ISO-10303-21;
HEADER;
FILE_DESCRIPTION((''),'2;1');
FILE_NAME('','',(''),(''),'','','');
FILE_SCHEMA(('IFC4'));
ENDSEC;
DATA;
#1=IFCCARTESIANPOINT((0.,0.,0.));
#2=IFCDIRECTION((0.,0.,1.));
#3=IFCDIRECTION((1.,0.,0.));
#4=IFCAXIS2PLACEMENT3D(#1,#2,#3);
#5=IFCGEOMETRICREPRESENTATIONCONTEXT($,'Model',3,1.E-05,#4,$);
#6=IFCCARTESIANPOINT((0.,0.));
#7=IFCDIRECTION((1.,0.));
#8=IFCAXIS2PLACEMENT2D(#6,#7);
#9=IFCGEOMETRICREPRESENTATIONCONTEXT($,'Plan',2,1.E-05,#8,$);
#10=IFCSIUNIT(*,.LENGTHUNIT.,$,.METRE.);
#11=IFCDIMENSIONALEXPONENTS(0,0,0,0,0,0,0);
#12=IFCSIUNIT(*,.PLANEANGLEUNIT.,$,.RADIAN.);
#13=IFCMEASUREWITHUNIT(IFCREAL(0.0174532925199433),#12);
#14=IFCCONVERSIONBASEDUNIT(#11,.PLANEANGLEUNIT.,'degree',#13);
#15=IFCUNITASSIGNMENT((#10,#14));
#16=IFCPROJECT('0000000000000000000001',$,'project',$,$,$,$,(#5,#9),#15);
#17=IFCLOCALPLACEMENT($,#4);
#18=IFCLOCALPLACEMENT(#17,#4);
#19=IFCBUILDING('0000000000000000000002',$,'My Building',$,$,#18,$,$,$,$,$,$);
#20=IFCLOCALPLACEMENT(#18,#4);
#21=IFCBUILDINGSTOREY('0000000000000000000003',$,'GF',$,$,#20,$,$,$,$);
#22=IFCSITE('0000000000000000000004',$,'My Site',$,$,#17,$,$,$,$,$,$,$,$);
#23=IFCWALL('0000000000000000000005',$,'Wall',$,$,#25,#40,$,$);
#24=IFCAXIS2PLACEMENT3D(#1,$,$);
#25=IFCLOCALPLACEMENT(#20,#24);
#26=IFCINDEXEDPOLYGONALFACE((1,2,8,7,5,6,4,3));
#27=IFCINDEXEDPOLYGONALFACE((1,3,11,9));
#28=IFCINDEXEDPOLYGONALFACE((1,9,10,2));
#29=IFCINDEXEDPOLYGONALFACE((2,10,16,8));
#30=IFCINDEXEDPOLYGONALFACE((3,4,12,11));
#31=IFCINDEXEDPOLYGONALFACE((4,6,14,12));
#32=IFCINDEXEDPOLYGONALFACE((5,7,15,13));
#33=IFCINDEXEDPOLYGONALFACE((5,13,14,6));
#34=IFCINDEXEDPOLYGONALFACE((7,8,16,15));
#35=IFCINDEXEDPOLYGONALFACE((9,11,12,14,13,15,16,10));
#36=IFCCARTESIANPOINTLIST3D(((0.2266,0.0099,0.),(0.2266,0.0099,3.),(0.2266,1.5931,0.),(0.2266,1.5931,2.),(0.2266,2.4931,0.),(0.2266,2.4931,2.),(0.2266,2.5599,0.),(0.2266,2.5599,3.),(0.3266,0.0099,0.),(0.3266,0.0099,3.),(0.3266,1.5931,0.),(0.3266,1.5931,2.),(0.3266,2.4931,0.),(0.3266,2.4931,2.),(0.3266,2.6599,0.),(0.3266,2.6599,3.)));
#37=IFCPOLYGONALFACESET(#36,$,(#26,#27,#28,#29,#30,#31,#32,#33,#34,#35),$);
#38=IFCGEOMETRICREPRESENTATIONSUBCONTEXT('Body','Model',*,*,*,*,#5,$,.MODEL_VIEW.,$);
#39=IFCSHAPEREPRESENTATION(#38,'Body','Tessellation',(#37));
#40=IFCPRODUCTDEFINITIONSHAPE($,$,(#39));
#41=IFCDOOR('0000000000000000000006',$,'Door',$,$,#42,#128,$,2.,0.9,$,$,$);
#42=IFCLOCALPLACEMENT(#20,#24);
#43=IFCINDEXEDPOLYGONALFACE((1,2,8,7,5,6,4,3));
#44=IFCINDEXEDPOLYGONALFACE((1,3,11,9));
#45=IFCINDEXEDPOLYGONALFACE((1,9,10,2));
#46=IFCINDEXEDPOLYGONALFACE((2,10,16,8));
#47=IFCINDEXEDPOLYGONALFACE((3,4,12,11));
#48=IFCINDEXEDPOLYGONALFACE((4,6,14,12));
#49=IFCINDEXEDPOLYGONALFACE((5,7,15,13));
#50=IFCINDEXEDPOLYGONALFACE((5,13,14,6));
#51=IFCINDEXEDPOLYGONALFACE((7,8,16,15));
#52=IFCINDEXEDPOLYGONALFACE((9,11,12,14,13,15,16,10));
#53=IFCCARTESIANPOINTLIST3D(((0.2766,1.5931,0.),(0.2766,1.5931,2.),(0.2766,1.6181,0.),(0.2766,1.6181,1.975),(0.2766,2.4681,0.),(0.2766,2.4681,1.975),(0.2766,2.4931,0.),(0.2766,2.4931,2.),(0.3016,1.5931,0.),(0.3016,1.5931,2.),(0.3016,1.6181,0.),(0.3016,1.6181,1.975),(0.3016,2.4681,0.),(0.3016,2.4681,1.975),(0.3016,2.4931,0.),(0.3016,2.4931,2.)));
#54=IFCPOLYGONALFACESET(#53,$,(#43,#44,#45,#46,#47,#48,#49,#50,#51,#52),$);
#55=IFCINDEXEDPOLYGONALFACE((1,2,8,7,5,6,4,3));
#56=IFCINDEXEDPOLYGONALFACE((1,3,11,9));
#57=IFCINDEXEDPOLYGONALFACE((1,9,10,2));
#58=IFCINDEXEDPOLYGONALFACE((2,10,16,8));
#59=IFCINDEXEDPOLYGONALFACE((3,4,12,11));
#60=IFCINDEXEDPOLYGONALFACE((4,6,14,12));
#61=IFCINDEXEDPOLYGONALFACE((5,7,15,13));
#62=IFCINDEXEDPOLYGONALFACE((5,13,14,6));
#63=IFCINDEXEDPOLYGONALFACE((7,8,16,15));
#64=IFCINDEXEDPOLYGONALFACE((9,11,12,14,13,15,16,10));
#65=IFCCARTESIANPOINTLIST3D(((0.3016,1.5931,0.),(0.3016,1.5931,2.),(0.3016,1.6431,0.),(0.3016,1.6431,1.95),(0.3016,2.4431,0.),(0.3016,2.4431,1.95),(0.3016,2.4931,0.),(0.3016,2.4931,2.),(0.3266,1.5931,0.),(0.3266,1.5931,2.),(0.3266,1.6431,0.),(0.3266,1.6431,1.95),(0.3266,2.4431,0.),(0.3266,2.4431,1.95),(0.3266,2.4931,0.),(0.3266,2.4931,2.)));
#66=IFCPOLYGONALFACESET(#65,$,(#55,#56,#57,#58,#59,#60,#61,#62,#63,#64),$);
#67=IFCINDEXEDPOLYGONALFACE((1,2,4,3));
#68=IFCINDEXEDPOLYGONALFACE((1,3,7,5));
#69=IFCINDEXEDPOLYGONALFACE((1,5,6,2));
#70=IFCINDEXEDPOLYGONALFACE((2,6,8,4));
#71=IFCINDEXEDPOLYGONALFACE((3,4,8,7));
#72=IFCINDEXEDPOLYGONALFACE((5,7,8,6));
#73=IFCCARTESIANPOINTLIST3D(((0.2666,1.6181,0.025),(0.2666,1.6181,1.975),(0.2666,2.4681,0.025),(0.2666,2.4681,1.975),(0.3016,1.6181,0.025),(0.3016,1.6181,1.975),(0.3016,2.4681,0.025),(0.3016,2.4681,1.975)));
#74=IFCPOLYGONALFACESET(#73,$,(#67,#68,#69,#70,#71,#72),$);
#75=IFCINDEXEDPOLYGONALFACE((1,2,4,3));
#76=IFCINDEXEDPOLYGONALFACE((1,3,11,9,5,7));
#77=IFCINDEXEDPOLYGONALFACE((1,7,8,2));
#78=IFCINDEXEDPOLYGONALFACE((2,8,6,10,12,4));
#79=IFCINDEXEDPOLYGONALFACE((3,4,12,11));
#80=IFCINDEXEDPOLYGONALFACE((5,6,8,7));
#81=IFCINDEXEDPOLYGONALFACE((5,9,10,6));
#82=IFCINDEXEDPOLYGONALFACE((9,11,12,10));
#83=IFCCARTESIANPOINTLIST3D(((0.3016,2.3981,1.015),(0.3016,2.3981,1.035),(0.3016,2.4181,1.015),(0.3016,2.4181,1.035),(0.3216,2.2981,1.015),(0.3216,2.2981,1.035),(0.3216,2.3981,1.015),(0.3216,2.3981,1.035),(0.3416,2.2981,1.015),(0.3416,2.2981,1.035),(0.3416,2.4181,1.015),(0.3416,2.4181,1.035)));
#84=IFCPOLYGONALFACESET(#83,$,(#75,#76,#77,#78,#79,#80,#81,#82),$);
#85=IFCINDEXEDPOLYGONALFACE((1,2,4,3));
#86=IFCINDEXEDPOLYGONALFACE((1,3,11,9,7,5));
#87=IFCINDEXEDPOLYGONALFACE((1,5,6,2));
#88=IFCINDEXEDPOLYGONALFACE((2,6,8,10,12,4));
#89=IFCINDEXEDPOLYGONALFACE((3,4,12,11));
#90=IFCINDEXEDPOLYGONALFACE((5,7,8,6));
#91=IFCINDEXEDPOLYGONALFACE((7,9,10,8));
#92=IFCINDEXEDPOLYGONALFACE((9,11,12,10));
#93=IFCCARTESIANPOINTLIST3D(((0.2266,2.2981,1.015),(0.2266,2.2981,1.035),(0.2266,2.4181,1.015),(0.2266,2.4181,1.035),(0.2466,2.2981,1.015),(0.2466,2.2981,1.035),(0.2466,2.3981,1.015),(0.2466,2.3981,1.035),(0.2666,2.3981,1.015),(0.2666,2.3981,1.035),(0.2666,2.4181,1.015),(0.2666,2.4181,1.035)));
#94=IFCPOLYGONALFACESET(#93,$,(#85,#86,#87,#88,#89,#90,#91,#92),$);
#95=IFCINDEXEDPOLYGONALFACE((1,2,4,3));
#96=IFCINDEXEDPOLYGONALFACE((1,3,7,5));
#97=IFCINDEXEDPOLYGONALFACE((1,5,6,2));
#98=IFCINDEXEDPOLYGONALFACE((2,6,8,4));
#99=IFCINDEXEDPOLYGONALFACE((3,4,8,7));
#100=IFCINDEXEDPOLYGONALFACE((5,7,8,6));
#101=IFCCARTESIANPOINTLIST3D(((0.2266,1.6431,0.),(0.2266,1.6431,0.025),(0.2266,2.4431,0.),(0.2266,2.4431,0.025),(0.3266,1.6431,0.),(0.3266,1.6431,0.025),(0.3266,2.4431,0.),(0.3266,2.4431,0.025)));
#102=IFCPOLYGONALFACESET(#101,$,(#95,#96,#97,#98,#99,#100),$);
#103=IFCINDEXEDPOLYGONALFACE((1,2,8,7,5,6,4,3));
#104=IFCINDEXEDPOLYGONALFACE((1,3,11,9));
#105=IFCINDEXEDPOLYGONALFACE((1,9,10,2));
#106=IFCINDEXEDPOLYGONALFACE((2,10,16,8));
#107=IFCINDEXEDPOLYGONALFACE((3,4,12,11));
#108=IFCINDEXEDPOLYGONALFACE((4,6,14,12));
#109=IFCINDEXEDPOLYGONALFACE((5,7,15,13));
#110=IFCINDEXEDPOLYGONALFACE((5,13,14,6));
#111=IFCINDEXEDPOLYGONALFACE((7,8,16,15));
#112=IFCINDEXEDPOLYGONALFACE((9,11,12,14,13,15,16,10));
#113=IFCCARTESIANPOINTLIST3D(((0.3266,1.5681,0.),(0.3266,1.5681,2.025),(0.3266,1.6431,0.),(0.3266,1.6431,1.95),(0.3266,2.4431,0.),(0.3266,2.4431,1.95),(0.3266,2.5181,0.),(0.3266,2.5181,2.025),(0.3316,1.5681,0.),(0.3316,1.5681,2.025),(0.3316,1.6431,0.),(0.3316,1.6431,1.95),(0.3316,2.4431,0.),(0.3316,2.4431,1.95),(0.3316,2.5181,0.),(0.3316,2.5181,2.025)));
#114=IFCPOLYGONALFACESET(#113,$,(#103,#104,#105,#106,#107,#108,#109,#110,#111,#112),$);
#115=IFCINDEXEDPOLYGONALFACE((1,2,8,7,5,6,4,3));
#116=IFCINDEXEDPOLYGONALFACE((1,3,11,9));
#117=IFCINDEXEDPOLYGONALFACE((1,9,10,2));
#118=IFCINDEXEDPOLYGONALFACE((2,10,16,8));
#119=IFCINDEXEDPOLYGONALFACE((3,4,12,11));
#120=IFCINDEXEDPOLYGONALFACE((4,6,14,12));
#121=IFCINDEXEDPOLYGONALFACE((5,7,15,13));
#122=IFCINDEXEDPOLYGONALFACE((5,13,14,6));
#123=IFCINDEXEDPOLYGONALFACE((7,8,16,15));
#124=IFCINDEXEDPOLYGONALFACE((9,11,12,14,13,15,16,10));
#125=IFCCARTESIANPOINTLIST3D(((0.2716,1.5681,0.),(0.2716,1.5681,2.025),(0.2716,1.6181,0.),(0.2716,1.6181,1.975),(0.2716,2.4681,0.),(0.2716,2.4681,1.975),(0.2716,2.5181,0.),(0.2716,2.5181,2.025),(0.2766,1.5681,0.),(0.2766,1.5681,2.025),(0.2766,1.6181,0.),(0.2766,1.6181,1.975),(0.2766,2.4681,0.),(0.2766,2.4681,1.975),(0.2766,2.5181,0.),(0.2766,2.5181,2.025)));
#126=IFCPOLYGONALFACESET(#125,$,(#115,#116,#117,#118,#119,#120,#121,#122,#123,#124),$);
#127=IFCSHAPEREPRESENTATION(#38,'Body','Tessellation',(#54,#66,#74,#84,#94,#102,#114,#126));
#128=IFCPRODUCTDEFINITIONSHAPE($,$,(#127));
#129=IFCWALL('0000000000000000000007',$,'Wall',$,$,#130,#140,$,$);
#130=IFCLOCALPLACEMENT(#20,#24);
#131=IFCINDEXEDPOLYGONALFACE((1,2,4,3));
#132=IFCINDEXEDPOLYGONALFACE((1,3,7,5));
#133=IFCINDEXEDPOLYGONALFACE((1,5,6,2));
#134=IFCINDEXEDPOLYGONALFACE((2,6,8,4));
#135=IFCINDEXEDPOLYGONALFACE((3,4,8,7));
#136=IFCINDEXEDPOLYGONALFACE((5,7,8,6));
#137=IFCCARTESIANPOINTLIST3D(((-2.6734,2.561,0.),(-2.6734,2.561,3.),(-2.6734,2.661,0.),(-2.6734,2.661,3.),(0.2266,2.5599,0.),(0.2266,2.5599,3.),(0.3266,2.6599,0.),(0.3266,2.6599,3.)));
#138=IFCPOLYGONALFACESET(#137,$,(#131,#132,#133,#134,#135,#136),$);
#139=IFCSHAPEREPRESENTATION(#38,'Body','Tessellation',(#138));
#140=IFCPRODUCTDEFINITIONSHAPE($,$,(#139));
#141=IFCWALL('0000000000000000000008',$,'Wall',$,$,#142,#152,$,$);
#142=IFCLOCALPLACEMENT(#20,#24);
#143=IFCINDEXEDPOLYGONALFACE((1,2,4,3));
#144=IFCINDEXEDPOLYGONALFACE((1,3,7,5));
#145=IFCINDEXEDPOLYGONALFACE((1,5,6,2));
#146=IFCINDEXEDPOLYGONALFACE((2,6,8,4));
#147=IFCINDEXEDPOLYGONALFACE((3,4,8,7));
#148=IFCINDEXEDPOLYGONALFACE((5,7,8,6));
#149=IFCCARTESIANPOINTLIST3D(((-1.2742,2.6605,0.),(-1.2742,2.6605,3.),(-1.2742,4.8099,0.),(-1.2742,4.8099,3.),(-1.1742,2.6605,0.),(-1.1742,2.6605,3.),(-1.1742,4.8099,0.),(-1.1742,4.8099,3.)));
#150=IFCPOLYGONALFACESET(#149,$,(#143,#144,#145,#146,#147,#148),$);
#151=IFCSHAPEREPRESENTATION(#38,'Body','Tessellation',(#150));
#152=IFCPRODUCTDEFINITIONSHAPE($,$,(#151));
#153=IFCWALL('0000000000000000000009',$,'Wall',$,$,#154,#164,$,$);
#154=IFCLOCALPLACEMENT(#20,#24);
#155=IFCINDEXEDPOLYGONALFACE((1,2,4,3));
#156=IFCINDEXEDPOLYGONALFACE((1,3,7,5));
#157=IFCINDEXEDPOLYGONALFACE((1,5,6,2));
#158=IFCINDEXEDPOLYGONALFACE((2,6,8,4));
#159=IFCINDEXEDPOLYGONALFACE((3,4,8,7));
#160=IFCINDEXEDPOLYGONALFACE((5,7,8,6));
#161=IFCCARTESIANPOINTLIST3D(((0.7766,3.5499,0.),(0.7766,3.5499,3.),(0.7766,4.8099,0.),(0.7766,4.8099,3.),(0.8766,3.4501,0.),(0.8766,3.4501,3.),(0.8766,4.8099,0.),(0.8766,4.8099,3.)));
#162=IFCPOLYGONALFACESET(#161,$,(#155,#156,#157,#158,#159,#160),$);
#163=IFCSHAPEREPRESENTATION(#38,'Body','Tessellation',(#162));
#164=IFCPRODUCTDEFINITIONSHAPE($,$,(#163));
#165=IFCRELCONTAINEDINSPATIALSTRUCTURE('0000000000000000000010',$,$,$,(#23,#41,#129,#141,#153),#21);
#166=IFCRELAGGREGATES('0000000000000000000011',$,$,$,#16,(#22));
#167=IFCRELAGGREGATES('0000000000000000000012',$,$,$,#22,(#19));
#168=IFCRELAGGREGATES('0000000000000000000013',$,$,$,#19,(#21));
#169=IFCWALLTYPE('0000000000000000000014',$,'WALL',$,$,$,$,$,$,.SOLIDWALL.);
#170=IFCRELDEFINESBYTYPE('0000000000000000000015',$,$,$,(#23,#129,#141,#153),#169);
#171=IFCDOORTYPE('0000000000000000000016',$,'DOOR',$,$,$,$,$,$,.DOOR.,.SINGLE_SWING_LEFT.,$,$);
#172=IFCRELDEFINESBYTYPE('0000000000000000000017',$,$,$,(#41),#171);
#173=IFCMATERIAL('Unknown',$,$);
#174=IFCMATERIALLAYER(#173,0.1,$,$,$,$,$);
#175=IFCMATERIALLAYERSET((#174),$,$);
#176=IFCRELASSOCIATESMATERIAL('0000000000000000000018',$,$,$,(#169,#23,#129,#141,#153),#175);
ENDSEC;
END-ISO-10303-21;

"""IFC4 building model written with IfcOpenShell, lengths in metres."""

from ifc_helpers import new_model, entity, si_unit, converted_unit, frame, origin_with_axes, origin_2d_with_axis, place, context, subcontext, project, spatial, line, indexed_curve, outline, extrude, shape, source, transform, mapped, material, layer, layer_set, layer_usage, type_object, type_shapes, element, fill, save


model = new_model("IFC4")

# Units and contexts
model_context = context("Model", 3, precision=1e-05, world=origin_with_axes())
plan_context = context("Plan", 2, precision=1e-05, world=origin_2d_with_axis())
body_context_1 = subcontext(model_context, "Body", "Model", "MODEL_VIEW")
body_context_2 = subcontext(plan_context, "Body", "Plan", "PLAN_VIEW")
ifc_project = project(units=[si_unit("LENGTHUNIT", "METRE"), converted_unit("PLANEANGLEUNIT", "degree", entity("IfcReal", 0.0174532925199433), si_unit("PLANEANGLEUNIT", "RADIAN"), dimensions=[0, 0, 0, 0, 0, 0, 0])], contexts=[model_context, plan_context])

# Site, building, storey
site_placement = place(None, origin_with_axes())
site = spatial("IfcSite", under=ifc_project, at=site_placement, Name="My Site")
building_placement = place(site_placement, origin_with_axes())
building = spatial("IfcBuilding", under=site, at=building_placement, Name="My Building")
storey_placement = place(building_placement, origin_with_axes())
storey = spatial("IfcBuildingStorey", under=building, at=storey_placement, Name="GF")

# Shared definitions
ifc_material_1 = material(Name="Unknown")

# Shared definitions
ifc_layer_1 = layer(ifc_material_1, 0.1)
ifc_layer_set_1 = layer_set([ifc_layer_1])
wall_type = type_object("IfcWallType", Name="WALL", PredefinedType="SOLIDWALL", material=ifc_layer_set_1)
shared_shape_1 = source(origin_with_axes(), body_context_1, "Body", "SweptSolid", [
    extrude(outline(indexed_curve([(0.0, 0.0), (0.9, 0.0), (0.9, 2.0), (0.0, 2.0)], segments=[line(1, 2, 3, 4, 1)])), frame((0.0, -0.6, 0.0), z_axis=(0.0, -1.0, 0.0), x_axis=(1.0, 0.0, 0.0)), (0.0, 0.0, -1.0), 1.2),
])
door_type = type_object("IfcDoorType", Name="DOOR", OperationType="SINGLE_SWING_LEFT", PredefinedType="DOOR")
shared_shape_2 = source(origin_with_axes(), body_context_1, "Body", "SweptSolid", [
    extrude(outline(indexed_curve([(0.0, 0.0), (0.0, 2.0), (0.9, 2.0), (0.9, 0.0), (0.875, 0.0), (0.875, 1.975), (0.025, 1.975), (0.025, 0.0)], segments=[line(1, 2, 3, 4, 5, 6, 7, 8, 1)])), frame((0.0, 0.025, 0.0), z_axis=(0.0, -1.0, 0.0), x_axis=(1.0, 0.0, 0.0)), (0.0, 0.0, -1.0), 0.025),
    extrude(outline(indexed_curve([(0.0, 0.0), (0.0, 2.0), (0.9, 2.0), (0.9, 0.0), (0.85, 0.0), (0.85, 1.95), (0.05, 1.95), (0.05, 0.0)], segments=[line(1, 2, 3, 4, 5, 6, 7, 8, 1)])), frame((0.0, 0.0, 0.0), z_axis=(0.0, -1.0, 0.0), x_axis=(1.0, 0.0, 0.0)), (0.0, 0.0, -1.0), 0.025),
    extrude(outline(indexed_curve([(0.0, 0.0), (0.85, 0.0), (0.85, 0.035), (0.0, 0.035)], segments=[line(1, 2, 3, 4, 1)])), frame((0.025, 0.025, 0.025), z_axis=(0.0, 0.0, 1.0), x_axis=(1.0, 0.0, 0.0)), (0.0, 0.0, 1.0), 1.95),
    extrude(outline(indexed_curve([(0.0, 0.0), (0.0, -0.04), (-0.12, -0.04), (-0.12, -0.02), (-0.02, -0.02), (-0.02, 0.0)], segments=[line(1, 2, 3, 4, 5, 6, 1)])), frame((0.825, 0.025, 1.015), z_axis=(0.0, 0.0, 1.0), x_axis=(1.0, 0.0, 0.0)), (0.0, 0.0, 1.0), 0.02),
    extrude(outline(indexed_curve([(0.0, 0.0), (0.0, 0.04), (-0.12, 0.04), (-0.12, 0.02), (-0.02, 0.02), (-0.02, 0.0)], segments=[line(1, 2, 3, 4, 5, 6, 1)])), frame((0.825, 0.06, 1.015), z_axis=(0.0, 0.0, 1.0), x_axis=(1.0, 0.0, 0.0)), (0.0, 0.0, 1.0), 0.02),
    extrude(outline(indexed_curve([(0.0, 0.0), (0.8, 0.0), (0.8, 0.1), (0.0, 0.1)], segments=[line(1, 2, 3, 4, 1)])), frame((0.05, 0.0, 0.0), z_axis=(0.0, 0.0, 1.0), x_axis=(1.0, 0.0, 0.0)), (0.0, 0.0, 1.0), 0.025),
    extrude(outline(indexed_curve([(0.0, 0.0), (0.0, 2.025), (0.95, 2.025), (0.95, 0.0), (0.875, 0.0), (0.875, 1.95), (0.075, 1.95), (0.075, 0.0)], segments=[line(1, 2, 3, 4, 5, 6, 7, 8, 1)])), frame((-0.025, -0.005, 0.0), z_axis=(0.0, -1.0, 0.0), x_axis=(1.0, 0.0, 0.0)), (0.0, 0.0, -1.0), 0.005),
    extrude(outline(indexed_curve([(0.0, 0.0), (0.0, 2.025), (0.95, 2.025), (0.95, 0.0), (0.9, 0.0), (0.9, 1.975), (0.05, 1.975), (0.05, 0.0)], segments=[line(1, 2, 3, 4, 5, 6, 7, 8, 1)])), frame((-0.025, 0.05, 0.0), z_axis=(0.0, -1.0, 0.0), x_axis=(1.0, 0.0, 0.0)), (0.0, 0.0, -1.0), 0.005),
])
shared_shape_3 = source(origin_with_axes(), body_context_2, "Body", "Curve2D", [
    entity("IfcIndexedPolyCurve", entity("IfcCartesianPointList2D", [[0.0, 0.0], [0.0, 0.05], [0.025, 0.05], [0.025, 0.025], [0.05, 0.025], [0.05, 0.0]]), [entity("IfcLineIndex", [1, 2, 3, 4, 5, 6, 1])]),
    entity("IfcIndexedPolyCurve", entity("IfcCartesianPointList2D", [[0.9, 0.0], [0.9, 0.05], [0.875, 0.05], [0.875, 0.025], [0.85, 0.025], [0.85, 0.0]]), [entity("IfcLineIndex", [1, 2, 3, 4, 5, 6, 1])]),
    entity("IfcTrimmedCurve", entity("IfcEllipse", entity("IfcAxis2Placement2D", entity("IfcCartesianPoint", [0.06, 0.05]), entity("IfcDirection", [1.0, 0.0])), 0.815, 0.85), [entity("IfcCartesianPoint", [0.875, 0.05])], [entity("IfcCartesianPoint", [0.06, 0.9])], True, "CARTESIAN"),
    entity("IfcIndexedPolyCurve", entity("IfcCartesianPointList2D", [[0.025, 0.05], [0.06, 0.05], [0.06, 0.9], [0.025, 0.9]]), [entity("IfcLineIndex", [1, 2, 3, 4, 1])]),
])
type_shapes(door_type, [shared_shape_2, shared_shape_3])

# Wall, opening, door
ifc_layer_usage_1 = layer_usage(ifc_layer_set_1, "AXIS2", "POSITIVE", 0.0)
wall_1_placement = place(storey_placement, frame((0.3266, 0.0099, 0.0), z_axis=(0.0, 0.0, 1.0), x_axis=(0.0, 1.0, 0.0)))
wall_1 = element("IfcWall", 1, at=wall_1_placement, inside=storey, type_object=wall_type, material=ifc_layer_usage_1, Name="Wall", context=body_context_1, shape_type="SweptSolid", body=[
    extrude(outline(indexed_curve([(0.0, 0.0), (0.0, 0.1), (2.55, 0.1), (2.65, 0.0)], segments=[line(1, 2, 3, 4, 1)])), origin_with_axes(), (0.0, 0.0, 1.0), 3.0),
])
opening_1_placement = place(wall_1_placement, frame((1.5832, 0.0, 0.0), z_axis=(0.0, 0.0, 1.0), x_axis=(1.0, 0.0, 0.0)))
opening_1 = element("IfcOpeningElement", 2, at=opening_1_placement, cuts=wall_1, PredefinedType="OPENING", context=body_context_1, shape_type="MappedRepresentation", body=[
    mapped(shared_shape_1, transform((0.0, 0.0, 0.0), x_axis=(1.0, 0.0, 0.0), y_axis=(0.0, 1.0, 0.0), z_axis=(0.0, 0.0, 1.0), scale=1.0)),
])
door_1_placement = place(opening_1_placement, frame((0.0, 0.0, 0.0), z_axis=(0.0, 0.0, 1.0), x_axis=(1.0, 0.0, 0.0)))
door_1 = element("IfcDoor", 3, at=door_1_placement, inside=storey, type_object=door_type, Name="Door", OverallHeight=2.0, OverallWidth=0.9, shapes=[
    shape(body_context_1, "Body", "MappedRepresentation", [mapped(shared_shape_2, transform((0.0, 0.0, 0.0), x_axis=(1.0, 0.0, 0.0), y_axis=(0.0, 1.0, 0.0), z_axis=(0.0, 0.0, 1.0), scale=1.0))]),
    shape(body_context_2, "Body", "MappedRepresentation", [mapped(shared_shape_3, transform((0.0, 0.0, 0.0), x_axis=(1.0, 0.0, 0.0), y_axis=(0.0, 1.0, 0.0), z_axis=(0.0, 0.0, 1.0), scale=1.0))]),
])
fill(opening_1, door_1)

# Walls
ifc_layer_usage_2 = layer_usage(ifc_layer_set_1, "AXIS2", "POSITIVE", 0.0)
wall_2_placement = place(storey_placement, frame((0.3266, 2.6599, 0.0), z_axis=(0.0, 0.0, 1.0), x_axis=(-1.0, 0.000374, 0.0)))
element("IfcWall", 4, at=wall_2_placement, inside=storey, type_object=wall_type, material=ifc_layer_usage_2, Name="Wall", context=body_context_1, shape_type="SweptSolid", body=[
    extrude(outline(indexed_curve([(0.0, 0.0), (0.1, 0.1), (3.0, 0.1), (3.0, 0.0)], segments=[line(1, 2, 3, 4, 1)])), origin_with_axes(), (0.0, 0.0, 1.0), 3.0),
])
ifc_layer_usage_3 = layer_usage(ifc_layer_set_1, "AXIS2", "POSITIVE", 0.0)
wall_3_placement = place(storey_placement, frame((-1.2742, 4.8099, 0.0), z_axis=(0.0, 0.0, 1.0), x_axis=(-0.000003, -1.0, 0.0)))
element("IfcWall", 5, at=wall_3_placement, inside=storey, type_object=wall_type, material=ifc_layer_usage_3, Name="Wall", context=body_context_1, shape_type="SweptSolid", body=[
    extrude(outline(indexed_curve([(0.0, 0.0), (0.0, 0.1), (2.1494, 0.1), (2.1494, 0.0)], segments=[line(1, 2, 3, 4, 1)])), origin_with_axes(), (0.0, 0.0, 1.0), 3.0),
])
ifc_layer_usage_4 = layer_usage(ifc_layer_set_1, "AXIS2", "POSITIVE", 0.0)
wall_4_placement = place(storey_placement, frame((0.7766, 4.8099, 0.0), z_axis=(0.0, 0.0, 1.0), x_axis=(0.0, -1.0, 0.0)))
element("IfcWall", 6, at=wall_4_placement, inside=storey, type_object=wall_type, material=ifc_layer_usage_4, Name="Wall", context=body_context_1, shape_type="SweptSolid", body=[
    extrude(outline(indexed_curve([(0.0, 0.0), (0.0, 0.1), (1.3598, 0.1), (1.26, 0.0)], segments=[line(1, 2, 3, 4, 1)])), origin_with_axes(), (0.0, 0.0, 1.0), 3.0),
])

save(model, "model.ifc")
